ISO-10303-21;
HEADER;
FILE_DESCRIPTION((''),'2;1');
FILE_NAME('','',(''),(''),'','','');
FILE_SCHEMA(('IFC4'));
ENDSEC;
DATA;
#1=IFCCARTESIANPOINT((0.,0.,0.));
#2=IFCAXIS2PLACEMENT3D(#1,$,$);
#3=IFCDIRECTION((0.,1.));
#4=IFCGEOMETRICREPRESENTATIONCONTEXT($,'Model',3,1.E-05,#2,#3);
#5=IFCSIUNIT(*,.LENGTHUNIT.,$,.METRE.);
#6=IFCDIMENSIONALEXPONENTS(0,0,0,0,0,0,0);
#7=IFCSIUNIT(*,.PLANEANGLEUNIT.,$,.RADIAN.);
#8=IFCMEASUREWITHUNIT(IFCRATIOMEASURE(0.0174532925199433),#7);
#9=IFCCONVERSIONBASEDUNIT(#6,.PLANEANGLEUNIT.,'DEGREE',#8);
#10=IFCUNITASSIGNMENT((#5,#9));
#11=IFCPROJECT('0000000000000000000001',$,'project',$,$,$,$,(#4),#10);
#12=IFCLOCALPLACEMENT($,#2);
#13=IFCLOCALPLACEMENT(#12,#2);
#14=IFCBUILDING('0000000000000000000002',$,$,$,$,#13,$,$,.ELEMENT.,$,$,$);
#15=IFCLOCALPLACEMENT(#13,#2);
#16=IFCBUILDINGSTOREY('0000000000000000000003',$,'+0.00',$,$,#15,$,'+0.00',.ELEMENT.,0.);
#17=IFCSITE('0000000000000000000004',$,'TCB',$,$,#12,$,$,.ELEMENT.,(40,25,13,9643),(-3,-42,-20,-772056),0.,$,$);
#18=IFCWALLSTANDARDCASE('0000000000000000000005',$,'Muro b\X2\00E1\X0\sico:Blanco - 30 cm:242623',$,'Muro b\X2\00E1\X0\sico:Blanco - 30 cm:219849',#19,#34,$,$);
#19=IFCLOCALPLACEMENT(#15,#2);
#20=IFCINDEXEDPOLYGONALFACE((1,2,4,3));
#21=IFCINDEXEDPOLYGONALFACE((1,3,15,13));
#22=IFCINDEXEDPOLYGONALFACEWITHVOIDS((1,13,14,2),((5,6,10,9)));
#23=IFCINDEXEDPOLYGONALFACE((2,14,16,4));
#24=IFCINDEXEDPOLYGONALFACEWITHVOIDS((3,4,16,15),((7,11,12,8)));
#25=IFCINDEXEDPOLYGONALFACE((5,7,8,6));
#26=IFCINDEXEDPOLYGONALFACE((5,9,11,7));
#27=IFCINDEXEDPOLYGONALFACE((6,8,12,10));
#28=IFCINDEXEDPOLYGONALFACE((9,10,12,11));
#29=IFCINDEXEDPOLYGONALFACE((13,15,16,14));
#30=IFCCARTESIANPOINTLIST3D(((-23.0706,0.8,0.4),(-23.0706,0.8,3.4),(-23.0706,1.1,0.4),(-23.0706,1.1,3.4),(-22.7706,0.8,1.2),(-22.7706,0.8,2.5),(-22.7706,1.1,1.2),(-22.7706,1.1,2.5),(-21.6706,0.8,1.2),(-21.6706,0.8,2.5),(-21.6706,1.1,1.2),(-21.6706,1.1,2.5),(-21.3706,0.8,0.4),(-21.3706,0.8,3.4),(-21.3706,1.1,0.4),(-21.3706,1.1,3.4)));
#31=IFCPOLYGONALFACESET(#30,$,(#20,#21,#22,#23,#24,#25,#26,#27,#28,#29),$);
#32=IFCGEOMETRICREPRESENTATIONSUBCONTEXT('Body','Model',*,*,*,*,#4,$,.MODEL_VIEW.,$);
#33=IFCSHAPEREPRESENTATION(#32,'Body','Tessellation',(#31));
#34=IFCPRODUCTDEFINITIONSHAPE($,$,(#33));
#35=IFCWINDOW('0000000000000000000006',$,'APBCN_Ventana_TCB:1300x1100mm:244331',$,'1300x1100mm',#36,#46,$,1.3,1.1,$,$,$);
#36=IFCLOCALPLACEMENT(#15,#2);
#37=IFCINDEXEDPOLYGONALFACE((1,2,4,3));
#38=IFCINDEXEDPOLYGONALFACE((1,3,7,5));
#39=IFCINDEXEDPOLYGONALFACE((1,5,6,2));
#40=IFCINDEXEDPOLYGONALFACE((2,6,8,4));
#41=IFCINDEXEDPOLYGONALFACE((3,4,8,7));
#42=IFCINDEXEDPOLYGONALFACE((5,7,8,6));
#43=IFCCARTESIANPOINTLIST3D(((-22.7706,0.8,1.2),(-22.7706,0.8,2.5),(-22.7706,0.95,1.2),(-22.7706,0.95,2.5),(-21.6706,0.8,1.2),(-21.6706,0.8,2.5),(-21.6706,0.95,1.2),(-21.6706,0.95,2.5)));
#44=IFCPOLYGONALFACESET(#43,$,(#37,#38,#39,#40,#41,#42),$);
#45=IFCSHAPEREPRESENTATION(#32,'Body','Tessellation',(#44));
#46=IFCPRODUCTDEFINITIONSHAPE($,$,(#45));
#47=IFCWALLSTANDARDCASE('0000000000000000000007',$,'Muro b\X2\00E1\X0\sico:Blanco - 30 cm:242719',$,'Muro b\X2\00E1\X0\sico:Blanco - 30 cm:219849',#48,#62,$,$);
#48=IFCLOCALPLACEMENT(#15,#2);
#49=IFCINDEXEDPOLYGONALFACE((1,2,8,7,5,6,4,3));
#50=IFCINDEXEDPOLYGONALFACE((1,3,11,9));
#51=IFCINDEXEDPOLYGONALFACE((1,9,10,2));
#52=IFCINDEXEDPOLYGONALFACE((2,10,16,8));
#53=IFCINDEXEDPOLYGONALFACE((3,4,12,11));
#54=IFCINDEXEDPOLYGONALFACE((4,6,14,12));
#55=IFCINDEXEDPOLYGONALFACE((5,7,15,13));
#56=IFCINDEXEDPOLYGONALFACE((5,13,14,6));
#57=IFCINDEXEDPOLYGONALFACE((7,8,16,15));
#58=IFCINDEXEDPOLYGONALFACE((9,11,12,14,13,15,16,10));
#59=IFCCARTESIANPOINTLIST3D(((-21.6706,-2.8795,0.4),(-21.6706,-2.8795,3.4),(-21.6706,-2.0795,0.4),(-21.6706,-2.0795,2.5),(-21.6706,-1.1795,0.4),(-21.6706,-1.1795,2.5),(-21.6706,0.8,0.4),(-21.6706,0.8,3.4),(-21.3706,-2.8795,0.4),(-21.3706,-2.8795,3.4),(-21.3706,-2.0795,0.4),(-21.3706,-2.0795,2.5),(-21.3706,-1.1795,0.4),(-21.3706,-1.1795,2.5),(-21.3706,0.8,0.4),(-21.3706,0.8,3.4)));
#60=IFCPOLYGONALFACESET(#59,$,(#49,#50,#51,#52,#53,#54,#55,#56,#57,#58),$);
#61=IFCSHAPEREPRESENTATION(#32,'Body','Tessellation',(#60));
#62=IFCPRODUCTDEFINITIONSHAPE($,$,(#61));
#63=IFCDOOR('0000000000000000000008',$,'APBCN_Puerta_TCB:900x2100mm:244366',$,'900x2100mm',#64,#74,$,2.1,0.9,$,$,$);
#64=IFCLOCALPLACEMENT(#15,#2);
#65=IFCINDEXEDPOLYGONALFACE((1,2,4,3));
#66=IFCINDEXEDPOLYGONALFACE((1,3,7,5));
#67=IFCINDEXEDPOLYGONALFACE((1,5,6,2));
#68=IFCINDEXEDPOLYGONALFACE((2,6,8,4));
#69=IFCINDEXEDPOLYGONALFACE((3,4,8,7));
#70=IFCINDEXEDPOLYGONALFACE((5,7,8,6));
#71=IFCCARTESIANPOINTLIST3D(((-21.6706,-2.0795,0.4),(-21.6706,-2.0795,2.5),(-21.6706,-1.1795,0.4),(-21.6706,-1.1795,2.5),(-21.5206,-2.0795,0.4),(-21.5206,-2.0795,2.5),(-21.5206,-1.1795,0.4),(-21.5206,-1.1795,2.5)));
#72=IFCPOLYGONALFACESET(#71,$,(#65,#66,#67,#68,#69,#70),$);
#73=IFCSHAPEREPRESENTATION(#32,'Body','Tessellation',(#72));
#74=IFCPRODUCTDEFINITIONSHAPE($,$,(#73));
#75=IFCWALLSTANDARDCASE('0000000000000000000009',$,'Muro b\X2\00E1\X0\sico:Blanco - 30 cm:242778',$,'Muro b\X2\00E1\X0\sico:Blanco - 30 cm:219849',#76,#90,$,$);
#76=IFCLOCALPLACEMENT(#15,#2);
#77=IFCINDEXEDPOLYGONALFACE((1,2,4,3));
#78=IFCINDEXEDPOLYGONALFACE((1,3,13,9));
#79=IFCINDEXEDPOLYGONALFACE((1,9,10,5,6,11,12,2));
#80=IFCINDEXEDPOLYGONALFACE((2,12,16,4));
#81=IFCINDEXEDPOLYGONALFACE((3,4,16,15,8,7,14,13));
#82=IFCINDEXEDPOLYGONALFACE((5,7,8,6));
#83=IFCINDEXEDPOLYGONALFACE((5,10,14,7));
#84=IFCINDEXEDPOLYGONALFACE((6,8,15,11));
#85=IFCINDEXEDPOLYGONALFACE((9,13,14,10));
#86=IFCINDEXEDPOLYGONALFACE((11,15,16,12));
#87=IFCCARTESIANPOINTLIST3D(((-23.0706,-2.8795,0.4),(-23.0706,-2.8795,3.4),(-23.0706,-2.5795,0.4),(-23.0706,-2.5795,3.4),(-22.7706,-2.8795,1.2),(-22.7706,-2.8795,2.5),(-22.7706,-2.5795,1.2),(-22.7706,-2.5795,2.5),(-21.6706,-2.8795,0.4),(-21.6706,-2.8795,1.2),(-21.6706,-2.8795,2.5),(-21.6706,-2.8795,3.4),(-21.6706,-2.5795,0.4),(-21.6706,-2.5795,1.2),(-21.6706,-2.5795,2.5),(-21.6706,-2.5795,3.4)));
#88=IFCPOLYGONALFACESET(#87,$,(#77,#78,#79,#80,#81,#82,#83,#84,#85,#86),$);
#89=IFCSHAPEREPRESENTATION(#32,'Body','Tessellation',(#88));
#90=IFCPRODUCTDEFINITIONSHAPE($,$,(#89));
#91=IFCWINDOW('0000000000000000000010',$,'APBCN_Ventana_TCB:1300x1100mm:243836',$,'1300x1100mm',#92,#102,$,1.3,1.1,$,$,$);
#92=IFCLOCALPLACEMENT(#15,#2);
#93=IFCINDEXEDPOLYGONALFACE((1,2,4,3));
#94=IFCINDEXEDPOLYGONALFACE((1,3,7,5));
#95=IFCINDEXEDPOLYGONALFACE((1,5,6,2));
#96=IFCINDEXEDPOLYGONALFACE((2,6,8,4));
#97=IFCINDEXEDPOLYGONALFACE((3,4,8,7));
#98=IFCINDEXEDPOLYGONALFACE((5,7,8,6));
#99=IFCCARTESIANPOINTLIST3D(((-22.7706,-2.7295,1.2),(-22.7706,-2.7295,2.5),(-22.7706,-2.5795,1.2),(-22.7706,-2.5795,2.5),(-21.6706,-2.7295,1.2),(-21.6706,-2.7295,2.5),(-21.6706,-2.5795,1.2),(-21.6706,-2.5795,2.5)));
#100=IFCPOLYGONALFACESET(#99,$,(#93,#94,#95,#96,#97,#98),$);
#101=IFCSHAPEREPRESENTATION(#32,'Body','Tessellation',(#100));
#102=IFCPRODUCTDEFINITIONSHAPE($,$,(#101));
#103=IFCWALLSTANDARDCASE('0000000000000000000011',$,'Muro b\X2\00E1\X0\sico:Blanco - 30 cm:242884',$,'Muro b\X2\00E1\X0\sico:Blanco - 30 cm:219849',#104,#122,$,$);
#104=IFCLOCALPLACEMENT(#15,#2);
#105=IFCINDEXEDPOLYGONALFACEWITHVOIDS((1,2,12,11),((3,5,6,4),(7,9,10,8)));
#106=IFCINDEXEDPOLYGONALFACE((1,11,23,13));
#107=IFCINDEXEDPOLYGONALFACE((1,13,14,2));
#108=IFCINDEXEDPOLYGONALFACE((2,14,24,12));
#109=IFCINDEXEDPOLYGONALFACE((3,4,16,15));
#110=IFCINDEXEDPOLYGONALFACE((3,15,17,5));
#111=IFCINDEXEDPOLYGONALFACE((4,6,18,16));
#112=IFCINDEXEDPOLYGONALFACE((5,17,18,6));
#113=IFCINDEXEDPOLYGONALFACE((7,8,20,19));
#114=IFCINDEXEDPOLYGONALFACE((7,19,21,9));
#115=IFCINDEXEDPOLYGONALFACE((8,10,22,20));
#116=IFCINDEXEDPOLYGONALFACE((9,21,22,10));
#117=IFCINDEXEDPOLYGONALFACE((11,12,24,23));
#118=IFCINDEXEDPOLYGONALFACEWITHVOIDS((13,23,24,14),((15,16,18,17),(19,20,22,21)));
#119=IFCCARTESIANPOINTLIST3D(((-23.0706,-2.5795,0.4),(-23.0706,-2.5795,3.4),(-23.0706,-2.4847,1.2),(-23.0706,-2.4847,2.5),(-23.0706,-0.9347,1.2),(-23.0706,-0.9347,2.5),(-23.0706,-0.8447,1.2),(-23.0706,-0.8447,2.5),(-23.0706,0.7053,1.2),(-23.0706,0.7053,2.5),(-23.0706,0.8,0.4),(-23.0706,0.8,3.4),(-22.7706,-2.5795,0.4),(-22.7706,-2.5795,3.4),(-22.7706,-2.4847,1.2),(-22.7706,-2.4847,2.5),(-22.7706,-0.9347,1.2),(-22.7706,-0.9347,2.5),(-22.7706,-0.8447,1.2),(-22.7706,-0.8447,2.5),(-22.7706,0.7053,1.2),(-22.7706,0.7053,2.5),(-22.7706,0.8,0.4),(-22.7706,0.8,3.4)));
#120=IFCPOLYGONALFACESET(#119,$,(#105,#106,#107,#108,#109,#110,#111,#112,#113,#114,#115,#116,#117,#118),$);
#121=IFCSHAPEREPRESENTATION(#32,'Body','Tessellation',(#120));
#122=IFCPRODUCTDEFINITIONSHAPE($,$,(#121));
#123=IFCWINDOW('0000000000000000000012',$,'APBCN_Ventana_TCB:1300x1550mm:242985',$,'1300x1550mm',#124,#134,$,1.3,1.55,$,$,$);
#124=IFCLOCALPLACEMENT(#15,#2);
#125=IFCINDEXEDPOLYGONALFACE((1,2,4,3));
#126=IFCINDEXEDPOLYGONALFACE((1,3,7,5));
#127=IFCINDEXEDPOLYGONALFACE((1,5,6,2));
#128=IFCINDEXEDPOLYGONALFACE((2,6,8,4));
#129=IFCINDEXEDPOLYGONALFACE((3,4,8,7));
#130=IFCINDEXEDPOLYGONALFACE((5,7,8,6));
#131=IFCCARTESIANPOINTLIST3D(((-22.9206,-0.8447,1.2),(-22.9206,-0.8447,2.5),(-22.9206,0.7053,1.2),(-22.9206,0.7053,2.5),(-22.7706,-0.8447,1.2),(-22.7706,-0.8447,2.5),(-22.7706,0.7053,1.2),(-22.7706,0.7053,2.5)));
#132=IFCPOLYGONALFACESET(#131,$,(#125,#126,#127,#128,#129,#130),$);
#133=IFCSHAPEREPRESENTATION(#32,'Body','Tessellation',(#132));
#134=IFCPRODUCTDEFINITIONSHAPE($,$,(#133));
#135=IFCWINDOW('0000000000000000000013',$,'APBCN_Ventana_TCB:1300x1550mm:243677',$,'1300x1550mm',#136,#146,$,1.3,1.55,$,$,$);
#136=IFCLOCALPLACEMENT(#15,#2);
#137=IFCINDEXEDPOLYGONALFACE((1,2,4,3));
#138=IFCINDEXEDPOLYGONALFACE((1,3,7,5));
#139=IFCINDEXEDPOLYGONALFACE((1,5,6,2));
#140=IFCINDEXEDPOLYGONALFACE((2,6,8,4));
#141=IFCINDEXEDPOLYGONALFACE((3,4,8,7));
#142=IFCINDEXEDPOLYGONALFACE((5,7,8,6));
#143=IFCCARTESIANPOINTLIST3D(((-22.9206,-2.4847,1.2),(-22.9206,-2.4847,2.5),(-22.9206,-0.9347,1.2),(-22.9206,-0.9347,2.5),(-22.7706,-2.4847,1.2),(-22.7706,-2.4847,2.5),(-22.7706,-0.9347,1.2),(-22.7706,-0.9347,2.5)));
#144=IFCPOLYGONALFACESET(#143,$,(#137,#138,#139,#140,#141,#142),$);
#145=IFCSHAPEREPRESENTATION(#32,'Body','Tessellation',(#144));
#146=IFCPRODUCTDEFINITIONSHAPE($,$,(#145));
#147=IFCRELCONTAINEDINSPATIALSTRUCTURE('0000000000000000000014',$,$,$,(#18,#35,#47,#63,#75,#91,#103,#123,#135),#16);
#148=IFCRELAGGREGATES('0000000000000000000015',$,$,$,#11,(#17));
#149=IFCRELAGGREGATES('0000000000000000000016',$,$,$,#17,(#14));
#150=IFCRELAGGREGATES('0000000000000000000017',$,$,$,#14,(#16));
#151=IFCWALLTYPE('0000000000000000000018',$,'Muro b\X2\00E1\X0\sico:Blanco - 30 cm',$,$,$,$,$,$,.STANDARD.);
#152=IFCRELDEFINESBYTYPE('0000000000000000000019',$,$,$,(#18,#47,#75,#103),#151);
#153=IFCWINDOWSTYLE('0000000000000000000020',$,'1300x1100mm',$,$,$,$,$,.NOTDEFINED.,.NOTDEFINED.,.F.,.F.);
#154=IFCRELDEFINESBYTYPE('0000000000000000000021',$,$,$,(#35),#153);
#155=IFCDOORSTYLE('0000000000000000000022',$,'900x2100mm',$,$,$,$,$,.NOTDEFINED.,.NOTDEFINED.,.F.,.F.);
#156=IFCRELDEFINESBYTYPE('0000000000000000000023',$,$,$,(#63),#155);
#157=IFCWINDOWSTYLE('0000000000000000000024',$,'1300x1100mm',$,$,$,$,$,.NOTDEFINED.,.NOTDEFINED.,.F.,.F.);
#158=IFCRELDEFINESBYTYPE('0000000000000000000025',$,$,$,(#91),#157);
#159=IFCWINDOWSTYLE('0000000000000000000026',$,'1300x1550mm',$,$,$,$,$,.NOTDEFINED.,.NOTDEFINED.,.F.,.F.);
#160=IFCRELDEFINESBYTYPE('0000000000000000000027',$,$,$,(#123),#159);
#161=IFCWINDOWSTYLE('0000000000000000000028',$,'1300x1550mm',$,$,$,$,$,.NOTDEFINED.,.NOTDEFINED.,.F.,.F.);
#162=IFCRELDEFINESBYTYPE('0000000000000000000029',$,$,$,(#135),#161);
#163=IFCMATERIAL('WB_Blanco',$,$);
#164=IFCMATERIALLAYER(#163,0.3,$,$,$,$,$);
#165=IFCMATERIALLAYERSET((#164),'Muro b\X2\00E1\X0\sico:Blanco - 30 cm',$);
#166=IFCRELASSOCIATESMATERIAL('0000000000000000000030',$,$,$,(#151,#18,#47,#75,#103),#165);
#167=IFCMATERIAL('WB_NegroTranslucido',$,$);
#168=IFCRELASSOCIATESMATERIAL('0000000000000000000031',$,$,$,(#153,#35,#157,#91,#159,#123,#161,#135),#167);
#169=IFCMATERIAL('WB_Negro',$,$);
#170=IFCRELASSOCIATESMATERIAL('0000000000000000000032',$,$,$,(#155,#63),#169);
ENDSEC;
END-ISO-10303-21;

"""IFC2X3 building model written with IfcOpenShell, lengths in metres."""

from ifc_helpers import new_model, entity, si_unit, converted_unit, direction, frame, frame_2d, origin, origin_2d_with_axis, place, context, subcontext, project, spatial, rectangle, extrude, source, transform, mapped, material, layer, layer_set, layer_usage, type_object, type_shapes, element, fill, save


model = new_model("IFC2X3")

# Units and contexts
model_context = context("Model", 3, precision=1e-05, world=origin(), true_north=direction((0.0, 1.0)))
body_context = subcontext(model_context, "Body", "Model", "MODEL_VIEW")
ifc_project = project(units=[si_unit("LENGTHUNIT", "METRE"), converted_unit("PLANEANGLEUNIT", "DEGREE", entity("IfcRatioMeasure", 0.0174532925199433), si_unit("PLANEANGLEUNIT", "RADIAN"), dimensions=[0, 0, 0, 0, 0, 0, 0])], contexts=[model_context])

# Site, building, storey
site_placement = place(None, origin())
site = spatial("IfcSite", under=ifc_project, at=site_placement, Name="TCB", CompositionType="ELEMENT", RefLatitude=(40, 25, 13, 9643), RefLongitude=(-3, -42, -20, -772056), RefElevation=0.0)
building_placement = place(site_placement, origin())
building = spatial("IfcBuilding", under=site, at=building_placement, CompositionType="ELEMENT")
storey_placement = place(building_placement, origin())
storey = spatial("IfcBuildingStorey", under=building, at=storey_placement, Name="+0.00", LongName="+0.00", CompositionType="ELEMENT", Elevation=0.0)

# Wall, opening, window
ifc_material_1 = material(Name="WB_Blanco")
ifc_layer = layer(ifc_material_1, 0.3)
ifc_layer_set = layer_set([ifc_layer], Name="Muro básico:Blanco - 30 cm")
ifc_layer_usage_1 = layer_usage(ifc_layer_set, "AXIS2", "NEGATIVE", 0.15)
wall_type = type_object("IfcWallType", Name="Muro básico:Blanco - 30 cm", PredefinedType="STANDARD", material=ifc_layer_set)
wall_1_placement = place(storey_placement, frame((-23.0706, 0.95, 0.4)))
wall_1 = element("IfcWallStandardCase", 1, at=wall_1_placement, inside=storey, type_object=wall_type, material=ifc_layer_usage_1, Name="Muro básico:Blanco - 30 cm:242623", ObjectType="Muro básico:Blanco - 30 cm:219849", context=body_context, shape_type="SweptSolid", body=[
    extrude(rectangle(XDim=1.7, YDim=0.3, at=frame_2d((0.85, 0.0), x_axis=(-1.0, 0.0))), origin(), (0.0, 0.0, 1.0), 3.0),
])
opening_1_placement = place(wall_1_placement, frame((0.3, -0.15, 0.8)))
opening_1 = element("IfcOpeningElement", 2, at=opening_1_placement, cuts=wall_1, ObjectType="Opening", context=body_context, shape_type="SweptSolid", body=[
    extrude(rectangle(XDim=1.3, YDim=1.1, at=frame_2d((0.65, 0.55), x_axis=(1.0, 0.0))), frame((0.0, 0.0, 0.0), z_axis=(0.0, 1.0, 0.0), x_axis=(0.0, 0.0, 1.0)), (0.0, 0.0, 1.0), 0.3),
])
ifc_material_2 = material(Name="WB_NegroTranslucido")
window_style_1 = type_object("IfcWindowStyle", Name="1300x1100mm", ConstructionType="NOTDEFINED", OperationType="NOTDEFINED", ParameterTakesPrecedence=False, Sizeable=False, material=ifc_material_2)
shared_shape_1 = source(origin(), body_context, "Body", "SweptSolid", [
    extrude(rectangle(XDim=0.15, YDim=1.1, at=frame_2d((0.0, 0.0), x_axis=(1.0, 0.0))), frame((0.55, 0.075, 0.0), z_axis=(0.0, 0.0, 1.0), x_axis=(0.0, 1.0, 0.0)), (0.0, 0.0, 1.0), 1.3),
])
type_shapes(window_style_1, [shared_shape_1])
window_1_placement = place(opening_1_placement, origin())
window_1 = element("IfcWindow", 3, at=window_1_placement, inside=storey, type_object=window_style_1, material=ifc_material_2, Name="APBCN_Ventana_TCB:1300x1100mm:244331", ObjectType="1300x1100mm", OverallHeight=1.3, OverallWidth=1.1, context=body_context, shape_type="MappedRepresentation", body=[
    mapped(shared_shape_1, transform((0.0, 0.0, 0.0), scale=1.0)),
])
fill(opening_1, window_1)

# Wall, opening, door
ifc_layer_usage_2 = layer_usage(ifc_layer_set, "AXIS2", "NEGATIVE", 0.15)
wall_2_placement = place(storey_placement, frame((-21.5206, 0.8, 0.4), z_axis=(0.0, 0.0, 1.0), x_axis=(0.0, -1.0, 0.0)))
wall_2 = element("IfcWallStandardCase", 4, at=wall_2_placement, inside=storey, type_object=wall_type, material=ifc_layer_usage_2, Name="Muro básico:Blanco - 30 cm:242719", ObjectType="Muro básico:Blanco - 30 cm:219849", context=body_context, shape_type="SweptSolid", body=[
    extrude(rectangle(XDim=3.6795, YDim=0.3, at=frame_2d((1.8397, 0.0), x_axis=(-1.0, 0.0))), origin(), (0.0, 0.0, 1.0), 3.0),
])
opening_2_placement = place(wall_2_placement, frame((1.9795, -0.15, 0.0)))
opening_2 = element("IfcOpeningElement", 5, at=opening_2_placement, cuts=wall_2, ObjectType="Opening", context=body_context, shape_type="SweptSolid", body=[
    extrude(rectangle(XDim=2.1, YDim=0.9, at=frame_2d((1.05, 0.45), x_axis=(1.0, 0.0))), frame((0.0, 0.0, 0.0), z_axis=(0.0, 1.0, 0.0), x_axis=(0.0, 0.0, 1.0)), (0.0, 0.0, 1.0), 0.3),
])
ifc_material_3 = material(Name="WB_Negro")
door_style = type_object("IfcDoorStyle", Name="900x2100mm", ConstructionType="NOTDEFINED", OperationType="NOTDEFINED", ParameterTakesPrecedence=False, Sizeable=False, material=ifc_material_3)
shared_shape_2 = source(origin(), body_context, "Body", "SweptSolid", [
    extrude(rectangle(XDim=0.15, YDim=0.9, at=frame_2d((0.0, 0.0), x_axis=(1.0, 0.0))), frame((0.45, 0.075, 0.0), z_axis=(0.0, 0.0, 1.0), x_axis=(0.0, 1.0, 0.0)), (0.0, 0.0, 1.0), 2.1),
])
type_shapes(door_style, [shared_shape_2])
door_1_placement = place(opening_2_placement, origin())
door_1 = element("IfcDoor", 6, at=door_1_placement, inside=storey, type_object=door_style, material=ifc_material_3, Name="APBCN_Puerta_TCB:900x2100mm:244366", ObjectType="900x2100mm", OverallHeight=2.1, OverallWidth=0.9, context=body_context, shape_type="MappedRepresentation", body=[
    mapped(shared_shape_2, transform((0.0, 0.0, 0.0), scale=1.0)),
])
fill(opening_2, door_1)

# Wall, opening, window
ifc_layer_usage_3 = layer_usage(ifc_layer_set, "AXIS2", "NEGATIVE", 0.15)
wall_3_placement = place(storey_placement, frame((-21.6706, -2.7295, 0.4), z_axis=(0.0, 0.0, 1.0), x_axis=(-1.0, 0.0, 0.0)))
wall_3 = element("IfcWallStandardCase", 7, at=wall_3_placement, inside=storey, type_object=wall_type, material=ifc_layer_usage_3, Name="Muro básico:Blanco - 30 cm:242778", ObjectType="Muro básico:Blanco - 30 cm:219849", context=body_context, shape_type="SweptSolid", body=[
    extrude(rectangle(XDim=1.4, YDim=0.3, at=frame_2d((0.7, 0.0), x_axis=(-1.0, 0.0))), origin(), (0.0, 0.0, 1.0), 3.0),
])
opening_3_placement = place(wall_3_placement, frame((0.0, -0.15, 0.8)))
opening_3 = element("IfcOpeningElement", 8, at=opening_3_placement, cuts=wall_3, ObjectType="Opening", context=body_context, shape_type="SweptSolid", body=[
    extrude(rectangle(XDim=1.3, YDim=1.1, at=frame_2d((0.65, 0.55), x_axis=(1.0, 0.0))), frame((0.0, 0.0, 0.0), z_axis=(0.0, 1.0, 0.0), x_axis=(0.0, 0.0, 1.0)), (0.0, 0.0, 1.0), 0.3),
])
window_style_2 = type_object("IfcWindowStyle", Name="1300x1100mm", ConstructionType="NOTDEFINED", OperationType="NOTDEFINED", ParameterTakesPrecedence=False, Sizeable=False, material=ifc_material_2)
shared_shape_3 = source(origin(), body_context, "Body", "SweptSolid", [
    extrude(rectangle(XDim=1.1, YDim=0.15, at=origin_2d_with_axis()), frame((0.55, 0.075, 0.0)), (0.0, 0.0, 1.0), 1.3),
])
type_shapes(window_style_2, [shared_shape_3])
window_2_placement = place(opening_3_placement, origin())
window_2 = element("IfcWindow", 9, at=window_2_placement, inside=storey, type_object=window_style_2, material=ifc_material_2, Name="APBCN_Ventana_TCB:1300x1100mm:243836", ObjectType="1300x1100mm", OverallHeight=1.3, OverallWidth=1.1, context=body_context, shape_type="MappedRepresentation", body=[
    mapped(shared_shape_3, transform((0.0, 0.0, 0.0), scale=1.0)),
])
fill(opening_3, window_2)

# Wall, openings, windows
ifc_layer_usage_4 = layer_usage(ifc_layer_set, "AXIS2", "NEGATIVE", 0.15)
wall_4_placement = place(storey_placement, frame((-22.9206, -2.5795, 0.4), z_axis=(0.0, 0.0, 1.0), x_axis=(0.0, 1.0, 0.0)))
wall_4 = element("IfcWallStandardCase", 10, at=wall_4_placement, inside=storey, type_object=wall_type, material=ifc_layer_usage_4, Name="Muro básico:Blanco - 30 cm:242884", ObjectType="Muro básico:Blanco - 30 cm:219849", context=body_context, shape_type="SweptSolid", body=[
    extrude(rectangle(XDim=3.3795, YDim=0.3, at=frame_2d((1.6897, 0.0), x_axis=(-1.0, 0.0))), origin(), (0.0, 0.0, 1.0), 3.0),
])
opening_4_placement = place(wall_4_placement, frame((1.7347, -0.15, 0.8)))
opening_4 = element("IfcOpeningElement", 11, at=opening_4_placement, cuts=wall_4, ObjectType="Opening", context=body_context, shape_type="SweptSolid", body=[
    extrude(rectangle(XDim=1.3, YDim=1.55, at=frame_2d((0.65, 0.775), x_axis=(1.0, 0.0))), frame((0.0, 0.0, 0.0), z_axis=(0.0, 1.0, 0.0), x_axis=(0.0, 0.0, 1.0)), (0.0, 0.0, 1.0), 0.3),
])
opening_5_placement = place(wall_4_placement, frame((0.0947, -0.15, 0.8)))
opening_5 = element("IfcOpeningElement", 12, at=opening_5_placement, cuts=wall_4, ObjectType="Opening", context=body_context, shape_type="SweptSolid", body=[
    extrude(rectangle(XDim=1.3, YDim=1.55, at=frame_2d((0.65, 0.775), x_axis=(1.0, 0.0))), frame((0.0, 0.0, 0.0), z_axis=(0.0, 1.0, 0.0), x_axis=(0.0, 0.0, 1.0)), (0.0, 0.0, 1.0), 0.3),
])
window_style_3 = type_object("IfcWindowStyle", Name="1300x1550mm", ConstructionType="NOTDEFINED", OperationType="NOTDEFINED", ParameterTakesPrecedence=False, Sizeable=False, material=ifc_material_2)
shared_shape_4 = source(origin(), body_context, "Body", "SweptSolid", [
    extrude(rectangle(XDim=1.55, YDim=0.15, at=origin_2d_with_axis()), frame((0.775, 0.075, 0.0)), (0.0, 0.0, 1.0), 1.3),
])
type_shapes(window_style_3, [shared_shape_4])
window_3_placement = place(opening_4_placement, origin())
window_3 = element("IfcWindow", 13, at=window_3_placement, inside=storey, type_object=window_style_3, material=ifc_material_2, Name="APBCN_Ventana_TCB:1300x1550mm:242985", ObjectType="1300x1550mm", OverallHeight=1.3, OverallWidth=1.55, context=body_context, shape_type="MappedRepresentation", body=[
    mapped(shared_shape_4, transform((0.0, 0.0, 0.0), scale=1.0)),
])
fill(opening_4, window_3)
window_style_4 = type_object("IfcWindowStyle", Name="1300x1550mm", ConstructionType="NOTDEFINED", OperationType="NOTDEFINED", ParameterTakesPrecedence=False, Sizeable=False, material=ifc_material_2)
shared_shape_5 = source(origin(), body_context, "Body", "SweptSolid", [
    extrude(rectangle(XDim=0.15, YDim=1.55, at=origin_2d_with_axis()), frame((0.775, 0.075, 0.0), z_axis=(0.0, 0.0, 1.0), x_axis=(0.0, 1.0, 0.0)), (0.0, 0.0, 1.0), 1.3),
])
type_shapes(window_style_4, [shared_shape_5])
window_4_placement = place(opening_5_placement, origin())
window_4 = element("IfcWindow", 14, at=window_4_placement, inside=storey, type_object=window_style_4, material=ifc_material_2, Name="APBCN_Ventana_TCB:1300x1550mm:243677", ObjectType="1300x1550mm", OverallHeight=1.3, OverallWidth=1.55, context=body_context, shape_type="MappedRepresentation", body=[
    mapped(shared_shape_5, transform((0.0, 0.0, 0.0), scale=1.0)),
])
fill(opening_5, window_4)

save(model, "model.ifc")
